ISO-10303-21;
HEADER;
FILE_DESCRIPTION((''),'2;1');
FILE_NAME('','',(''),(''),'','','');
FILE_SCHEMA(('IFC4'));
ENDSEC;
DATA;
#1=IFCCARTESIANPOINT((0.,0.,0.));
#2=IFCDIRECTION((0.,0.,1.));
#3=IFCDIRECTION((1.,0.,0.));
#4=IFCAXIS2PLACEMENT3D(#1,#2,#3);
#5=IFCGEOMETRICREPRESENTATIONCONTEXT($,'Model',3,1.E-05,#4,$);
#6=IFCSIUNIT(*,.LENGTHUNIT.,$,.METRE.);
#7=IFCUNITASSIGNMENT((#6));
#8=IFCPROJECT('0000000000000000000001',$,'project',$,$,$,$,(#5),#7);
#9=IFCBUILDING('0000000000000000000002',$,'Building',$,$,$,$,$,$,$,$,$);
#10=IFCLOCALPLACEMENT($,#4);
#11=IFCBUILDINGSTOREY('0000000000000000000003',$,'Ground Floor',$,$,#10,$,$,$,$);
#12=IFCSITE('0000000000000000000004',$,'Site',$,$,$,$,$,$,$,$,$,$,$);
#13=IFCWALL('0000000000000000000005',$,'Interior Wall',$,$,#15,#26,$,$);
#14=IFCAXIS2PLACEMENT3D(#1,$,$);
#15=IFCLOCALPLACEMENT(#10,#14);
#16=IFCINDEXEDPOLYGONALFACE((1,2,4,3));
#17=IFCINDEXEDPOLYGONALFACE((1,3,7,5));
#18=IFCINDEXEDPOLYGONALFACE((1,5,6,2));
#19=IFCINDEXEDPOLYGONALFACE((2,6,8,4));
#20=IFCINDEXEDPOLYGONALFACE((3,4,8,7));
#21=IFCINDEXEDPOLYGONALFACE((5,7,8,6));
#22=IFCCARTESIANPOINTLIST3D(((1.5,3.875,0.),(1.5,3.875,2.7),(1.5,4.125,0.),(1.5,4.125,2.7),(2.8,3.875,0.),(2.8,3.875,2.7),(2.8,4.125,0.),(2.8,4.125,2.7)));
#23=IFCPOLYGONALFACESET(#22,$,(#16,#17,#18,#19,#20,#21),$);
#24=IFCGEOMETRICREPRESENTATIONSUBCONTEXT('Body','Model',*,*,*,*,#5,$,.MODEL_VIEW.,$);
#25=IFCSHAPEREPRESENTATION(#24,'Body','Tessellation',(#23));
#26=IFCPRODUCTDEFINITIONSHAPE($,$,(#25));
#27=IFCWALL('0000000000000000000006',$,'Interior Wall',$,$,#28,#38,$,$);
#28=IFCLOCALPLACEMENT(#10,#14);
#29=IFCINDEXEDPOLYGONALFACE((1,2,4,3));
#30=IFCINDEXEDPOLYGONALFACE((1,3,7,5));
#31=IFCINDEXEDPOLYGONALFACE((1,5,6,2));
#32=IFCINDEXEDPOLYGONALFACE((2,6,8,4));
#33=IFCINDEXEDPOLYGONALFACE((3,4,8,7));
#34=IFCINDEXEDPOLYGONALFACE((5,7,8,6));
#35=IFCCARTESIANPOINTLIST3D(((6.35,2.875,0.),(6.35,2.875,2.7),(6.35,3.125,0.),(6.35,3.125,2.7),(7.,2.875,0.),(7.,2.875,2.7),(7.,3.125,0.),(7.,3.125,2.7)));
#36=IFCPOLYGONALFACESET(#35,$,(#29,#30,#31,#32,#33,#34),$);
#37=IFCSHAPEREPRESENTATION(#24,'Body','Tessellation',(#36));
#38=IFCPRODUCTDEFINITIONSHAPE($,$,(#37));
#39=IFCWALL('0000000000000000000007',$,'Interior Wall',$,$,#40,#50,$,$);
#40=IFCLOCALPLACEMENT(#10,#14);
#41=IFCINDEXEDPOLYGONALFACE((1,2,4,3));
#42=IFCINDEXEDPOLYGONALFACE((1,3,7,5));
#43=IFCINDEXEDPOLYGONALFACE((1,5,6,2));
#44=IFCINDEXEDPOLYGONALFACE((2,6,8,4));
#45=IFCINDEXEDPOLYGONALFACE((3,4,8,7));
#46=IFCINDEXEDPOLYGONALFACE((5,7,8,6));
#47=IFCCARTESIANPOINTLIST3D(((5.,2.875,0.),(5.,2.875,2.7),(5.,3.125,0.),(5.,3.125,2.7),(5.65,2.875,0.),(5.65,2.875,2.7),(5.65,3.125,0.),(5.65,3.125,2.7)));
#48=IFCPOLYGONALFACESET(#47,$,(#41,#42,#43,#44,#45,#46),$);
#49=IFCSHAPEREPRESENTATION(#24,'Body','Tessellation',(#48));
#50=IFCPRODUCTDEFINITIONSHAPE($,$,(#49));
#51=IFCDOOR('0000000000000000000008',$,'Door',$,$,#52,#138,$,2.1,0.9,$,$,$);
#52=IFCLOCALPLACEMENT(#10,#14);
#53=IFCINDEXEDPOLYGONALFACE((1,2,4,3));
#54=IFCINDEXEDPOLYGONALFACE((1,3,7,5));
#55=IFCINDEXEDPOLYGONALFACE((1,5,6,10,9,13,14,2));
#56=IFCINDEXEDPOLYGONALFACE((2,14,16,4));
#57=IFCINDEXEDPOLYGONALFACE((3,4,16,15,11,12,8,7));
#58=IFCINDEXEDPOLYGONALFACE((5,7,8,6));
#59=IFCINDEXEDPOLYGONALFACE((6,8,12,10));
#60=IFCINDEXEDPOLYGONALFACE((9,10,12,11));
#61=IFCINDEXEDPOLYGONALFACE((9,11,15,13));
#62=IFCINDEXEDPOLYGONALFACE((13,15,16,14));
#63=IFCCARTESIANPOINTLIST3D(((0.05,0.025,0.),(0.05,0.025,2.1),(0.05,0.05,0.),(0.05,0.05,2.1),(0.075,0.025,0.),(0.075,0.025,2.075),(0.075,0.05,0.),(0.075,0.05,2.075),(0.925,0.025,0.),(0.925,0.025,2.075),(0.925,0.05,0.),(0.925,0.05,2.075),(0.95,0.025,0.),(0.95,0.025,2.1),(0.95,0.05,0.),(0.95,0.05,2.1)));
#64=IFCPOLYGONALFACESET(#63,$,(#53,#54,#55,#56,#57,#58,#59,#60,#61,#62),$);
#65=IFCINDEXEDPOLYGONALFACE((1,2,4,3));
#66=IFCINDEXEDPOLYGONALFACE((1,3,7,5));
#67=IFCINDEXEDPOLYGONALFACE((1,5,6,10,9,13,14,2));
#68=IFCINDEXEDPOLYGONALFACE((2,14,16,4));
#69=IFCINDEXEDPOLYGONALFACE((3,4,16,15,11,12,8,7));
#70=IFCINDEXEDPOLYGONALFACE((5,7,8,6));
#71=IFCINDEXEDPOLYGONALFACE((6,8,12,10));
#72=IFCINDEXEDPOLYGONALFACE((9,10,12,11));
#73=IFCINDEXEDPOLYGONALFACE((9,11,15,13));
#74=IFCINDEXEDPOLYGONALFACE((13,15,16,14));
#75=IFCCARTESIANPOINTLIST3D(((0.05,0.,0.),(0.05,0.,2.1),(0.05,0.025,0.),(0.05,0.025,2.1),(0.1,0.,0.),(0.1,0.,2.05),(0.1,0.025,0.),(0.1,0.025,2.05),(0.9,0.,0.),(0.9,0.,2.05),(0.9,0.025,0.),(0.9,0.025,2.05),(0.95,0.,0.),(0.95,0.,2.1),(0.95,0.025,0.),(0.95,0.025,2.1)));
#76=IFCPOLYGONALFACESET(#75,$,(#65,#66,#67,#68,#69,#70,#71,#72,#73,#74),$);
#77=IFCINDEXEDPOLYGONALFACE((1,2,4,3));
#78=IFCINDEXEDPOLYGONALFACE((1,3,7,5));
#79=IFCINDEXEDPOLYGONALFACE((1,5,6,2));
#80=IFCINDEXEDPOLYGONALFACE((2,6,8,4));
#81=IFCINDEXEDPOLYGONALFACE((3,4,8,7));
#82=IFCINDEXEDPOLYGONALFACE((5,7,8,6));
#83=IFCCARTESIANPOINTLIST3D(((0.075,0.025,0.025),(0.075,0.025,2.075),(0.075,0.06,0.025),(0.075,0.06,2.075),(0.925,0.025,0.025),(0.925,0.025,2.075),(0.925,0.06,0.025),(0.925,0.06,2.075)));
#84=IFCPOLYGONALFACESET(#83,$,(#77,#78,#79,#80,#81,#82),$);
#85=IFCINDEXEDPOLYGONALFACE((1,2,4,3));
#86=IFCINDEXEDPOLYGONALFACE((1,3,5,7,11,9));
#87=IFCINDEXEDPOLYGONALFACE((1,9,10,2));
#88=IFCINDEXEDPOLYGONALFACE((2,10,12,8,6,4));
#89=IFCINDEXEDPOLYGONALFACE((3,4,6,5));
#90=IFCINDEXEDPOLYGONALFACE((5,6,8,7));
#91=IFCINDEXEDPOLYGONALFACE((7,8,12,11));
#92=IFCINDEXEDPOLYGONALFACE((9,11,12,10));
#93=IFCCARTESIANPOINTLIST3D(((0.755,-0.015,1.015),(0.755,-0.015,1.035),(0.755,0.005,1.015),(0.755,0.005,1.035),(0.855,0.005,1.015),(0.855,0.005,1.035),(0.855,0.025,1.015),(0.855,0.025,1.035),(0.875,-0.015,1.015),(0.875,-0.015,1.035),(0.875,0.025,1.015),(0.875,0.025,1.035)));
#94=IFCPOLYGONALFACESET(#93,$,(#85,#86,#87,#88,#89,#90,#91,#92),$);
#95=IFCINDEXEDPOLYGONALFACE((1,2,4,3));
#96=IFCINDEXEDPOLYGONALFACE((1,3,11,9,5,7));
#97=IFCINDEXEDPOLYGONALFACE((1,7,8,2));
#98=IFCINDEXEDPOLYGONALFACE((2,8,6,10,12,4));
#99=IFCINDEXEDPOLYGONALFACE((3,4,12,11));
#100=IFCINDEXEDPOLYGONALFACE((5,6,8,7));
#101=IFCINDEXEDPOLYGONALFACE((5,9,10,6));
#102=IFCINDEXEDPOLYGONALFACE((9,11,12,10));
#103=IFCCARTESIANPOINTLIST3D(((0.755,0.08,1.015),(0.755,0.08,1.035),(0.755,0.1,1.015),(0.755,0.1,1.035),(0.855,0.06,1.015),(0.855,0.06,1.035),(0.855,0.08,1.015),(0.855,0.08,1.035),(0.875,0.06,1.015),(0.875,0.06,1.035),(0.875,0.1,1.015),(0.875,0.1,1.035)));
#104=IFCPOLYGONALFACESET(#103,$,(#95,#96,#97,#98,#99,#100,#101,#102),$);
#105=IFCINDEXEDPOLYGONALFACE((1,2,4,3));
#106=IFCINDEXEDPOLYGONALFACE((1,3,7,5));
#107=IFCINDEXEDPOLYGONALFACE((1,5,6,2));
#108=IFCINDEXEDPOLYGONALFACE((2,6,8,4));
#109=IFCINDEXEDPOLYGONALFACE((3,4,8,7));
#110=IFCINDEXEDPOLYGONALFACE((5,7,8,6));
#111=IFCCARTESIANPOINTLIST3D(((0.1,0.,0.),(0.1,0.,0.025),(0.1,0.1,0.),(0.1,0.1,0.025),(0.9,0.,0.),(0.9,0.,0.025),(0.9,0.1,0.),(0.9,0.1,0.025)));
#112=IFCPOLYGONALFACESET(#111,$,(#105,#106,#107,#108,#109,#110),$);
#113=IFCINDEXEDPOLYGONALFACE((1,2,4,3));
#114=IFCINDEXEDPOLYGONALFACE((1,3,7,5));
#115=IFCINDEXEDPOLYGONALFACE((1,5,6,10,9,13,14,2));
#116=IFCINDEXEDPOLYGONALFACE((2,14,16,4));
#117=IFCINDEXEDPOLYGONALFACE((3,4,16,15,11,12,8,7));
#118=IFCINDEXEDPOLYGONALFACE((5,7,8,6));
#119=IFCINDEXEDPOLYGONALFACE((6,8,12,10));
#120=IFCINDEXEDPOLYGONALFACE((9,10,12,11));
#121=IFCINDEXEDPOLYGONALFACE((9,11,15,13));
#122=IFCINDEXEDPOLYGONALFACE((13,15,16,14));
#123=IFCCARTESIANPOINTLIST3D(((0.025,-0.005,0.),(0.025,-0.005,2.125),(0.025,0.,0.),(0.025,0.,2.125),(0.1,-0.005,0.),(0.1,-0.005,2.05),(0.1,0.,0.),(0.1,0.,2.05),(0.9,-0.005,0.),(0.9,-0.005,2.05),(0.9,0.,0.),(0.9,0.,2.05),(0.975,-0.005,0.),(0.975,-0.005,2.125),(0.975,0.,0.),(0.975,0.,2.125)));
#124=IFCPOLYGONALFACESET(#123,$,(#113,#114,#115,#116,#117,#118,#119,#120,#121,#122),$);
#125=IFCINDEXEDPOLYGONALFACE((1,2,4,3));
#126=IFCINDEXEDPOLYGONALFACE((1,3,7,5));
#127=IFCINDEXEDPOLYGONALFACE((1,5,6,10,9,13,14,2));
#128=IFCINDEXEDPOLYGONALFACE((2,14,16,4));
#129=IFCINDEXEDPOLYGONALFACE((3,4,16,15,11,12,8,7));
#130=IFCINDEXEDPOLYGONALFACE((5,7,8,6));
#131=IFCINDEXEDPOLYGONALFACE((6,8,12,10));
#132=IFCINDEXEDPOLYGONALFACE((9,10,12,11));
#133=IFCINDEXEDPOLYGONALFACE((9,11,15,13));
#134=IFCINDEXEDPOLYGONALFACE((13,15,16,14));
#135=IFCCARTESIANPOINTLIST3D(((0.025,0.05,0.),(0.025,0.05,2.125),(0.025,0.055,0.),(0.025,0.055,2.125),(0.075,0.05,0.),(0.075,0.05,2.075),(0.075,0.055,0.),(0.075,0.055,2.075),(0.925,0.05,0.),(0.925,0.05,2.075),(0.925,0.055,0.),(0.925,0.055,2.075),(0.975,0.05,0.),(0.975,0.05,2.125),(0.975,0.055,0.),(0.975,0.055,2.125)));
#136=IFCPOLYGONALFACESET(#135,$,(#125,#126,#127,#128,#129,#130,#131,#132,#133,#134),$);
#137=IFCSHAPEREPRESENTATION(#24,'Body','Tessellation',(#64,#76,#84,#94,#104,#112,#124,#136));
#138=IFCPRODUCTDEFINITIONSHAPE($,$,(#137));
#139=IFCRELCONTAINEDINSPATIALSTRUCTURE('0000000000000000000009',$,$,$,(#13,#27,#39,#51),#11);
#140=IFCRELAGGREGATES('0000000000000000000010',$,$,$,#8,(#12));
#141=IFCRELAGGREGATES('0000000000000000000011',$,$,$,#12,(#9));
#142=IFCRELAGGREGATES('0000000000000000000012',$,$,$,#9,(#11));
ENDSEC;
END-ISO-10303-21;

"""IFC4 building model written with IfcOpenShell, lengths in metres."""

from ifc_helpers import new_model, si_unit, frame, origin_with_axes, place, context, subcontext, project, spatial, line, indexed_curve, outline, extrude, element, save


model = new_model("IFC4")

# Units and contexts
model_context = context("Model", 3, precision=1e-05, world=origin_with_axes())
body_context = subcontext(model_context, "Body", "Model", "MODEL_VIEW")
ifc_project = project(units=[si_unit("LENGTHUNIT", "METRE")], contexts=[model_context])

# Site, building, storey
site = spatial("IfcSite", under=ifc_project, Name="Site")
building = spatial("IfcBuilding", under=site, Name="Building")
storey_placement = place(None, origin_with_axes())
storey = spatial("IfcBuildingStorey", under=building, at=storey_placement, Name="Ground Floor")

# Walls
for number, where, z_axis, x_axis, name in (
    (1, (2.8, 4.0, 0.0), (0.0, 0.0, 1.0), (-1.0, 0.0, 0.0), "Interior Wall"),
):
    element("IfcWall", number, at=place(storey_placement, frame(where, z_axis=z_axis, x_axis=x_axis)), inside=storey, Name=name, context=body_context, shape_type="SweptSolid", body=[
        extrude(outline(indexed_curve([(0.0, 0.0), (0.0, 0.25), (1.3, 0.25), (1.3, 0.0), (0.0, 0.0)], self_intersect=False)), frame((0.0, -0.125, 0.0), z_axis=(0.0, 0.0, 1.0), x_axis=(1.0, 0.0, 0.0)), (0.0, 0.0, 1.0), 2.7),
    ])
for number, where, z_axis, x_axis, name in (
    (2, (7.0, 3.0, 0.0), (0.0, 0.0, 1.0), (-1.0, 0.0, 0.0), "Interior Wall"),
    (3, (5.65, 3.0, 0.0), (0.0, 0.0, 1.0), (-1.0, 0.0, 0.0), "Interior Wall"),
):
    element("IfcWall", number, at=place(storey_placement, frame(where, z_axis=z_axis, x_axis=x_axis)), inside=storey, Name=name, context=body_context, shape_type="SweptSolid", body=[
        extrude(outline(indexed_curve([(0.0, 0.0), (0.0, 0.25), (0.65, 0.25), (0.65, 0.0), (0.0, 0.0)], self_intersect=False)), frame((0.0, -0.125, 0.0), z_axis=(0.0, 0.0, 1.0), x_axis=(1.0, 0.0, 0.0)), (0.0, 0.0, 1.0), 2.7),
    ])

# Door
door_1_placement = place(storey_placement, frame((0.05, 0.0, 0.0), z_axis=(0.0, 0.0, 1.0), x_axis=(1.0, 0.0, 0.0)))
element("IfcDoor", 4, at=door_1_placement, inside=storey, Name="Door", OverallHeight=2.1, OverallWidth=0.9, context=body_context, shape_type="SweptSolid", body=[
    extrude(outline(indexed_curve([(0.0, 0.0), (0.0, 2.1), (0.9, 2.1), (0.9, 0.0), (0.875, 0.0), (0.875, 2.075), (0.025, 2.075), (0.025, 0.0)], segments=[line(1, 2, 3, 4, 5, 6, 7, 8, 1)])), frame((0.0, 0.025, 0.0), z_axis=(0.0, -1.0, 0.0), x_axis=(1.0, 0.0, 0.0)), (0.0, 0.0, -1.0), 0.025),
    extrude(outline(indexed_curve([(0.0, 0.0), (0.0, 2.1), (0.9, 2.1), (0.9, 0.0), (0.85, 0.0), (0.85, 2.05), (0.05, 2.05), (0.05, 0.0)], segments=[line(1, 2, 3, 4, 5, 6, 7, 8, 1)])), frame((0.0, 0.0, 0.0), z_axis=(0.0, -1.0, 0.0), x_axis=(1.0, 0.0, 0.0)), (0.0, 0.0, -1.0), 0.025),
    extrude(outline(indexed_curve([(0.0, 0.0), (0.85, 0.0), (0.85, 0.035), (0.0, 0.035)], segments=[line(1, 2, 3, 4, 1)])), frame((0.025, 0.025, 0.025), z_axis=(0.0, 0.0, 1.0), x_axis=(1.0, 0.0, 0.0)), (0.0, 0.0, 1.0), 2.05),
    extrude(outline(indexed_curve([(0.0, 0.0), (0.0, -0.04), (-0.12, -0.04), (-0.12, -0.02), (-0.02, -0.02), (-0.02, 0.0)], segments=[line(1, 2, 3, 4, 5, 6, 1)])), frame((0.825, 0.025, 1.015), z_axis=(0.0, 0.0, 1.0), x_axis=(1.0, 0.0, 0.0)), (0.0, 0.0, 1.0), 0.02),
    extrude(outline(indexed_curve([(0.0, 0.0), (0.0, 0.04), (-0.12, 0.04), (-0.12, 0.02), (-0.02, 0.02), (-0.02, 0.0)], segments=[line(1, 2, 3, 4, 5, 6, 1)])), frame((0.825, 0.06, 1.015), z_axis=(0.0, 0.0, 1.0), x_axis=(1.0, 0.0, 0.0)), (0.0, 0.0, 1.0), 0.02),
    extrude(outline(indexed_curve([(0.0, 0.0), (0.8, 0.0), (0.8, 0.1), (0.0, 0.1)], segments=[line(1, 2, 3, 4, 1)])), frame((0.05, 0.0, 0.0), z_axis=(0.0, 0.0, 1.0), x_axis=(1.0, 0.0, 0.0)), (0.0, 0.0, 1.0), 0.025),
    extrude(outline(indexed_curve([(0.0, 0.0), (0.0, 2.125), (0.95, 2.125), (0.95, 0.0), (0.875, 0.0), (0.875, 2.05), (0.075, 2.05), (0.075, 0.0)], segments=[line(1, 2, 3, 4, 5, 6, 7, 8, 1)])), frame((-0.025, -0.005, 0.0), z_axis=(0.0, -1.0, 0.0), x_axis=(1.0, 0.0, 0.0)), (0.0, 0.0, -1.0), 0.005),
    extrude(outline(indexed_curve([(0.0, 0.0), (0.0, 2.125), (0.95, 2.125), (0.95, 0.0), (0.9, 0.0), (0.9, 2.075), (0.05, 2.075), (0.05, 0.0)], segments=[line(1, 2, 3, 4, 5, 6, 7, 8, 1)])), frame((-0.025, 0.05, 0.0), z_axis=(0.0, -1.0, 0.0), x_axis=(1.0, 0.0, 0.0)), (0.0, 0.0, -1.0), 0.005),
])

save(model, "model.ifc")
